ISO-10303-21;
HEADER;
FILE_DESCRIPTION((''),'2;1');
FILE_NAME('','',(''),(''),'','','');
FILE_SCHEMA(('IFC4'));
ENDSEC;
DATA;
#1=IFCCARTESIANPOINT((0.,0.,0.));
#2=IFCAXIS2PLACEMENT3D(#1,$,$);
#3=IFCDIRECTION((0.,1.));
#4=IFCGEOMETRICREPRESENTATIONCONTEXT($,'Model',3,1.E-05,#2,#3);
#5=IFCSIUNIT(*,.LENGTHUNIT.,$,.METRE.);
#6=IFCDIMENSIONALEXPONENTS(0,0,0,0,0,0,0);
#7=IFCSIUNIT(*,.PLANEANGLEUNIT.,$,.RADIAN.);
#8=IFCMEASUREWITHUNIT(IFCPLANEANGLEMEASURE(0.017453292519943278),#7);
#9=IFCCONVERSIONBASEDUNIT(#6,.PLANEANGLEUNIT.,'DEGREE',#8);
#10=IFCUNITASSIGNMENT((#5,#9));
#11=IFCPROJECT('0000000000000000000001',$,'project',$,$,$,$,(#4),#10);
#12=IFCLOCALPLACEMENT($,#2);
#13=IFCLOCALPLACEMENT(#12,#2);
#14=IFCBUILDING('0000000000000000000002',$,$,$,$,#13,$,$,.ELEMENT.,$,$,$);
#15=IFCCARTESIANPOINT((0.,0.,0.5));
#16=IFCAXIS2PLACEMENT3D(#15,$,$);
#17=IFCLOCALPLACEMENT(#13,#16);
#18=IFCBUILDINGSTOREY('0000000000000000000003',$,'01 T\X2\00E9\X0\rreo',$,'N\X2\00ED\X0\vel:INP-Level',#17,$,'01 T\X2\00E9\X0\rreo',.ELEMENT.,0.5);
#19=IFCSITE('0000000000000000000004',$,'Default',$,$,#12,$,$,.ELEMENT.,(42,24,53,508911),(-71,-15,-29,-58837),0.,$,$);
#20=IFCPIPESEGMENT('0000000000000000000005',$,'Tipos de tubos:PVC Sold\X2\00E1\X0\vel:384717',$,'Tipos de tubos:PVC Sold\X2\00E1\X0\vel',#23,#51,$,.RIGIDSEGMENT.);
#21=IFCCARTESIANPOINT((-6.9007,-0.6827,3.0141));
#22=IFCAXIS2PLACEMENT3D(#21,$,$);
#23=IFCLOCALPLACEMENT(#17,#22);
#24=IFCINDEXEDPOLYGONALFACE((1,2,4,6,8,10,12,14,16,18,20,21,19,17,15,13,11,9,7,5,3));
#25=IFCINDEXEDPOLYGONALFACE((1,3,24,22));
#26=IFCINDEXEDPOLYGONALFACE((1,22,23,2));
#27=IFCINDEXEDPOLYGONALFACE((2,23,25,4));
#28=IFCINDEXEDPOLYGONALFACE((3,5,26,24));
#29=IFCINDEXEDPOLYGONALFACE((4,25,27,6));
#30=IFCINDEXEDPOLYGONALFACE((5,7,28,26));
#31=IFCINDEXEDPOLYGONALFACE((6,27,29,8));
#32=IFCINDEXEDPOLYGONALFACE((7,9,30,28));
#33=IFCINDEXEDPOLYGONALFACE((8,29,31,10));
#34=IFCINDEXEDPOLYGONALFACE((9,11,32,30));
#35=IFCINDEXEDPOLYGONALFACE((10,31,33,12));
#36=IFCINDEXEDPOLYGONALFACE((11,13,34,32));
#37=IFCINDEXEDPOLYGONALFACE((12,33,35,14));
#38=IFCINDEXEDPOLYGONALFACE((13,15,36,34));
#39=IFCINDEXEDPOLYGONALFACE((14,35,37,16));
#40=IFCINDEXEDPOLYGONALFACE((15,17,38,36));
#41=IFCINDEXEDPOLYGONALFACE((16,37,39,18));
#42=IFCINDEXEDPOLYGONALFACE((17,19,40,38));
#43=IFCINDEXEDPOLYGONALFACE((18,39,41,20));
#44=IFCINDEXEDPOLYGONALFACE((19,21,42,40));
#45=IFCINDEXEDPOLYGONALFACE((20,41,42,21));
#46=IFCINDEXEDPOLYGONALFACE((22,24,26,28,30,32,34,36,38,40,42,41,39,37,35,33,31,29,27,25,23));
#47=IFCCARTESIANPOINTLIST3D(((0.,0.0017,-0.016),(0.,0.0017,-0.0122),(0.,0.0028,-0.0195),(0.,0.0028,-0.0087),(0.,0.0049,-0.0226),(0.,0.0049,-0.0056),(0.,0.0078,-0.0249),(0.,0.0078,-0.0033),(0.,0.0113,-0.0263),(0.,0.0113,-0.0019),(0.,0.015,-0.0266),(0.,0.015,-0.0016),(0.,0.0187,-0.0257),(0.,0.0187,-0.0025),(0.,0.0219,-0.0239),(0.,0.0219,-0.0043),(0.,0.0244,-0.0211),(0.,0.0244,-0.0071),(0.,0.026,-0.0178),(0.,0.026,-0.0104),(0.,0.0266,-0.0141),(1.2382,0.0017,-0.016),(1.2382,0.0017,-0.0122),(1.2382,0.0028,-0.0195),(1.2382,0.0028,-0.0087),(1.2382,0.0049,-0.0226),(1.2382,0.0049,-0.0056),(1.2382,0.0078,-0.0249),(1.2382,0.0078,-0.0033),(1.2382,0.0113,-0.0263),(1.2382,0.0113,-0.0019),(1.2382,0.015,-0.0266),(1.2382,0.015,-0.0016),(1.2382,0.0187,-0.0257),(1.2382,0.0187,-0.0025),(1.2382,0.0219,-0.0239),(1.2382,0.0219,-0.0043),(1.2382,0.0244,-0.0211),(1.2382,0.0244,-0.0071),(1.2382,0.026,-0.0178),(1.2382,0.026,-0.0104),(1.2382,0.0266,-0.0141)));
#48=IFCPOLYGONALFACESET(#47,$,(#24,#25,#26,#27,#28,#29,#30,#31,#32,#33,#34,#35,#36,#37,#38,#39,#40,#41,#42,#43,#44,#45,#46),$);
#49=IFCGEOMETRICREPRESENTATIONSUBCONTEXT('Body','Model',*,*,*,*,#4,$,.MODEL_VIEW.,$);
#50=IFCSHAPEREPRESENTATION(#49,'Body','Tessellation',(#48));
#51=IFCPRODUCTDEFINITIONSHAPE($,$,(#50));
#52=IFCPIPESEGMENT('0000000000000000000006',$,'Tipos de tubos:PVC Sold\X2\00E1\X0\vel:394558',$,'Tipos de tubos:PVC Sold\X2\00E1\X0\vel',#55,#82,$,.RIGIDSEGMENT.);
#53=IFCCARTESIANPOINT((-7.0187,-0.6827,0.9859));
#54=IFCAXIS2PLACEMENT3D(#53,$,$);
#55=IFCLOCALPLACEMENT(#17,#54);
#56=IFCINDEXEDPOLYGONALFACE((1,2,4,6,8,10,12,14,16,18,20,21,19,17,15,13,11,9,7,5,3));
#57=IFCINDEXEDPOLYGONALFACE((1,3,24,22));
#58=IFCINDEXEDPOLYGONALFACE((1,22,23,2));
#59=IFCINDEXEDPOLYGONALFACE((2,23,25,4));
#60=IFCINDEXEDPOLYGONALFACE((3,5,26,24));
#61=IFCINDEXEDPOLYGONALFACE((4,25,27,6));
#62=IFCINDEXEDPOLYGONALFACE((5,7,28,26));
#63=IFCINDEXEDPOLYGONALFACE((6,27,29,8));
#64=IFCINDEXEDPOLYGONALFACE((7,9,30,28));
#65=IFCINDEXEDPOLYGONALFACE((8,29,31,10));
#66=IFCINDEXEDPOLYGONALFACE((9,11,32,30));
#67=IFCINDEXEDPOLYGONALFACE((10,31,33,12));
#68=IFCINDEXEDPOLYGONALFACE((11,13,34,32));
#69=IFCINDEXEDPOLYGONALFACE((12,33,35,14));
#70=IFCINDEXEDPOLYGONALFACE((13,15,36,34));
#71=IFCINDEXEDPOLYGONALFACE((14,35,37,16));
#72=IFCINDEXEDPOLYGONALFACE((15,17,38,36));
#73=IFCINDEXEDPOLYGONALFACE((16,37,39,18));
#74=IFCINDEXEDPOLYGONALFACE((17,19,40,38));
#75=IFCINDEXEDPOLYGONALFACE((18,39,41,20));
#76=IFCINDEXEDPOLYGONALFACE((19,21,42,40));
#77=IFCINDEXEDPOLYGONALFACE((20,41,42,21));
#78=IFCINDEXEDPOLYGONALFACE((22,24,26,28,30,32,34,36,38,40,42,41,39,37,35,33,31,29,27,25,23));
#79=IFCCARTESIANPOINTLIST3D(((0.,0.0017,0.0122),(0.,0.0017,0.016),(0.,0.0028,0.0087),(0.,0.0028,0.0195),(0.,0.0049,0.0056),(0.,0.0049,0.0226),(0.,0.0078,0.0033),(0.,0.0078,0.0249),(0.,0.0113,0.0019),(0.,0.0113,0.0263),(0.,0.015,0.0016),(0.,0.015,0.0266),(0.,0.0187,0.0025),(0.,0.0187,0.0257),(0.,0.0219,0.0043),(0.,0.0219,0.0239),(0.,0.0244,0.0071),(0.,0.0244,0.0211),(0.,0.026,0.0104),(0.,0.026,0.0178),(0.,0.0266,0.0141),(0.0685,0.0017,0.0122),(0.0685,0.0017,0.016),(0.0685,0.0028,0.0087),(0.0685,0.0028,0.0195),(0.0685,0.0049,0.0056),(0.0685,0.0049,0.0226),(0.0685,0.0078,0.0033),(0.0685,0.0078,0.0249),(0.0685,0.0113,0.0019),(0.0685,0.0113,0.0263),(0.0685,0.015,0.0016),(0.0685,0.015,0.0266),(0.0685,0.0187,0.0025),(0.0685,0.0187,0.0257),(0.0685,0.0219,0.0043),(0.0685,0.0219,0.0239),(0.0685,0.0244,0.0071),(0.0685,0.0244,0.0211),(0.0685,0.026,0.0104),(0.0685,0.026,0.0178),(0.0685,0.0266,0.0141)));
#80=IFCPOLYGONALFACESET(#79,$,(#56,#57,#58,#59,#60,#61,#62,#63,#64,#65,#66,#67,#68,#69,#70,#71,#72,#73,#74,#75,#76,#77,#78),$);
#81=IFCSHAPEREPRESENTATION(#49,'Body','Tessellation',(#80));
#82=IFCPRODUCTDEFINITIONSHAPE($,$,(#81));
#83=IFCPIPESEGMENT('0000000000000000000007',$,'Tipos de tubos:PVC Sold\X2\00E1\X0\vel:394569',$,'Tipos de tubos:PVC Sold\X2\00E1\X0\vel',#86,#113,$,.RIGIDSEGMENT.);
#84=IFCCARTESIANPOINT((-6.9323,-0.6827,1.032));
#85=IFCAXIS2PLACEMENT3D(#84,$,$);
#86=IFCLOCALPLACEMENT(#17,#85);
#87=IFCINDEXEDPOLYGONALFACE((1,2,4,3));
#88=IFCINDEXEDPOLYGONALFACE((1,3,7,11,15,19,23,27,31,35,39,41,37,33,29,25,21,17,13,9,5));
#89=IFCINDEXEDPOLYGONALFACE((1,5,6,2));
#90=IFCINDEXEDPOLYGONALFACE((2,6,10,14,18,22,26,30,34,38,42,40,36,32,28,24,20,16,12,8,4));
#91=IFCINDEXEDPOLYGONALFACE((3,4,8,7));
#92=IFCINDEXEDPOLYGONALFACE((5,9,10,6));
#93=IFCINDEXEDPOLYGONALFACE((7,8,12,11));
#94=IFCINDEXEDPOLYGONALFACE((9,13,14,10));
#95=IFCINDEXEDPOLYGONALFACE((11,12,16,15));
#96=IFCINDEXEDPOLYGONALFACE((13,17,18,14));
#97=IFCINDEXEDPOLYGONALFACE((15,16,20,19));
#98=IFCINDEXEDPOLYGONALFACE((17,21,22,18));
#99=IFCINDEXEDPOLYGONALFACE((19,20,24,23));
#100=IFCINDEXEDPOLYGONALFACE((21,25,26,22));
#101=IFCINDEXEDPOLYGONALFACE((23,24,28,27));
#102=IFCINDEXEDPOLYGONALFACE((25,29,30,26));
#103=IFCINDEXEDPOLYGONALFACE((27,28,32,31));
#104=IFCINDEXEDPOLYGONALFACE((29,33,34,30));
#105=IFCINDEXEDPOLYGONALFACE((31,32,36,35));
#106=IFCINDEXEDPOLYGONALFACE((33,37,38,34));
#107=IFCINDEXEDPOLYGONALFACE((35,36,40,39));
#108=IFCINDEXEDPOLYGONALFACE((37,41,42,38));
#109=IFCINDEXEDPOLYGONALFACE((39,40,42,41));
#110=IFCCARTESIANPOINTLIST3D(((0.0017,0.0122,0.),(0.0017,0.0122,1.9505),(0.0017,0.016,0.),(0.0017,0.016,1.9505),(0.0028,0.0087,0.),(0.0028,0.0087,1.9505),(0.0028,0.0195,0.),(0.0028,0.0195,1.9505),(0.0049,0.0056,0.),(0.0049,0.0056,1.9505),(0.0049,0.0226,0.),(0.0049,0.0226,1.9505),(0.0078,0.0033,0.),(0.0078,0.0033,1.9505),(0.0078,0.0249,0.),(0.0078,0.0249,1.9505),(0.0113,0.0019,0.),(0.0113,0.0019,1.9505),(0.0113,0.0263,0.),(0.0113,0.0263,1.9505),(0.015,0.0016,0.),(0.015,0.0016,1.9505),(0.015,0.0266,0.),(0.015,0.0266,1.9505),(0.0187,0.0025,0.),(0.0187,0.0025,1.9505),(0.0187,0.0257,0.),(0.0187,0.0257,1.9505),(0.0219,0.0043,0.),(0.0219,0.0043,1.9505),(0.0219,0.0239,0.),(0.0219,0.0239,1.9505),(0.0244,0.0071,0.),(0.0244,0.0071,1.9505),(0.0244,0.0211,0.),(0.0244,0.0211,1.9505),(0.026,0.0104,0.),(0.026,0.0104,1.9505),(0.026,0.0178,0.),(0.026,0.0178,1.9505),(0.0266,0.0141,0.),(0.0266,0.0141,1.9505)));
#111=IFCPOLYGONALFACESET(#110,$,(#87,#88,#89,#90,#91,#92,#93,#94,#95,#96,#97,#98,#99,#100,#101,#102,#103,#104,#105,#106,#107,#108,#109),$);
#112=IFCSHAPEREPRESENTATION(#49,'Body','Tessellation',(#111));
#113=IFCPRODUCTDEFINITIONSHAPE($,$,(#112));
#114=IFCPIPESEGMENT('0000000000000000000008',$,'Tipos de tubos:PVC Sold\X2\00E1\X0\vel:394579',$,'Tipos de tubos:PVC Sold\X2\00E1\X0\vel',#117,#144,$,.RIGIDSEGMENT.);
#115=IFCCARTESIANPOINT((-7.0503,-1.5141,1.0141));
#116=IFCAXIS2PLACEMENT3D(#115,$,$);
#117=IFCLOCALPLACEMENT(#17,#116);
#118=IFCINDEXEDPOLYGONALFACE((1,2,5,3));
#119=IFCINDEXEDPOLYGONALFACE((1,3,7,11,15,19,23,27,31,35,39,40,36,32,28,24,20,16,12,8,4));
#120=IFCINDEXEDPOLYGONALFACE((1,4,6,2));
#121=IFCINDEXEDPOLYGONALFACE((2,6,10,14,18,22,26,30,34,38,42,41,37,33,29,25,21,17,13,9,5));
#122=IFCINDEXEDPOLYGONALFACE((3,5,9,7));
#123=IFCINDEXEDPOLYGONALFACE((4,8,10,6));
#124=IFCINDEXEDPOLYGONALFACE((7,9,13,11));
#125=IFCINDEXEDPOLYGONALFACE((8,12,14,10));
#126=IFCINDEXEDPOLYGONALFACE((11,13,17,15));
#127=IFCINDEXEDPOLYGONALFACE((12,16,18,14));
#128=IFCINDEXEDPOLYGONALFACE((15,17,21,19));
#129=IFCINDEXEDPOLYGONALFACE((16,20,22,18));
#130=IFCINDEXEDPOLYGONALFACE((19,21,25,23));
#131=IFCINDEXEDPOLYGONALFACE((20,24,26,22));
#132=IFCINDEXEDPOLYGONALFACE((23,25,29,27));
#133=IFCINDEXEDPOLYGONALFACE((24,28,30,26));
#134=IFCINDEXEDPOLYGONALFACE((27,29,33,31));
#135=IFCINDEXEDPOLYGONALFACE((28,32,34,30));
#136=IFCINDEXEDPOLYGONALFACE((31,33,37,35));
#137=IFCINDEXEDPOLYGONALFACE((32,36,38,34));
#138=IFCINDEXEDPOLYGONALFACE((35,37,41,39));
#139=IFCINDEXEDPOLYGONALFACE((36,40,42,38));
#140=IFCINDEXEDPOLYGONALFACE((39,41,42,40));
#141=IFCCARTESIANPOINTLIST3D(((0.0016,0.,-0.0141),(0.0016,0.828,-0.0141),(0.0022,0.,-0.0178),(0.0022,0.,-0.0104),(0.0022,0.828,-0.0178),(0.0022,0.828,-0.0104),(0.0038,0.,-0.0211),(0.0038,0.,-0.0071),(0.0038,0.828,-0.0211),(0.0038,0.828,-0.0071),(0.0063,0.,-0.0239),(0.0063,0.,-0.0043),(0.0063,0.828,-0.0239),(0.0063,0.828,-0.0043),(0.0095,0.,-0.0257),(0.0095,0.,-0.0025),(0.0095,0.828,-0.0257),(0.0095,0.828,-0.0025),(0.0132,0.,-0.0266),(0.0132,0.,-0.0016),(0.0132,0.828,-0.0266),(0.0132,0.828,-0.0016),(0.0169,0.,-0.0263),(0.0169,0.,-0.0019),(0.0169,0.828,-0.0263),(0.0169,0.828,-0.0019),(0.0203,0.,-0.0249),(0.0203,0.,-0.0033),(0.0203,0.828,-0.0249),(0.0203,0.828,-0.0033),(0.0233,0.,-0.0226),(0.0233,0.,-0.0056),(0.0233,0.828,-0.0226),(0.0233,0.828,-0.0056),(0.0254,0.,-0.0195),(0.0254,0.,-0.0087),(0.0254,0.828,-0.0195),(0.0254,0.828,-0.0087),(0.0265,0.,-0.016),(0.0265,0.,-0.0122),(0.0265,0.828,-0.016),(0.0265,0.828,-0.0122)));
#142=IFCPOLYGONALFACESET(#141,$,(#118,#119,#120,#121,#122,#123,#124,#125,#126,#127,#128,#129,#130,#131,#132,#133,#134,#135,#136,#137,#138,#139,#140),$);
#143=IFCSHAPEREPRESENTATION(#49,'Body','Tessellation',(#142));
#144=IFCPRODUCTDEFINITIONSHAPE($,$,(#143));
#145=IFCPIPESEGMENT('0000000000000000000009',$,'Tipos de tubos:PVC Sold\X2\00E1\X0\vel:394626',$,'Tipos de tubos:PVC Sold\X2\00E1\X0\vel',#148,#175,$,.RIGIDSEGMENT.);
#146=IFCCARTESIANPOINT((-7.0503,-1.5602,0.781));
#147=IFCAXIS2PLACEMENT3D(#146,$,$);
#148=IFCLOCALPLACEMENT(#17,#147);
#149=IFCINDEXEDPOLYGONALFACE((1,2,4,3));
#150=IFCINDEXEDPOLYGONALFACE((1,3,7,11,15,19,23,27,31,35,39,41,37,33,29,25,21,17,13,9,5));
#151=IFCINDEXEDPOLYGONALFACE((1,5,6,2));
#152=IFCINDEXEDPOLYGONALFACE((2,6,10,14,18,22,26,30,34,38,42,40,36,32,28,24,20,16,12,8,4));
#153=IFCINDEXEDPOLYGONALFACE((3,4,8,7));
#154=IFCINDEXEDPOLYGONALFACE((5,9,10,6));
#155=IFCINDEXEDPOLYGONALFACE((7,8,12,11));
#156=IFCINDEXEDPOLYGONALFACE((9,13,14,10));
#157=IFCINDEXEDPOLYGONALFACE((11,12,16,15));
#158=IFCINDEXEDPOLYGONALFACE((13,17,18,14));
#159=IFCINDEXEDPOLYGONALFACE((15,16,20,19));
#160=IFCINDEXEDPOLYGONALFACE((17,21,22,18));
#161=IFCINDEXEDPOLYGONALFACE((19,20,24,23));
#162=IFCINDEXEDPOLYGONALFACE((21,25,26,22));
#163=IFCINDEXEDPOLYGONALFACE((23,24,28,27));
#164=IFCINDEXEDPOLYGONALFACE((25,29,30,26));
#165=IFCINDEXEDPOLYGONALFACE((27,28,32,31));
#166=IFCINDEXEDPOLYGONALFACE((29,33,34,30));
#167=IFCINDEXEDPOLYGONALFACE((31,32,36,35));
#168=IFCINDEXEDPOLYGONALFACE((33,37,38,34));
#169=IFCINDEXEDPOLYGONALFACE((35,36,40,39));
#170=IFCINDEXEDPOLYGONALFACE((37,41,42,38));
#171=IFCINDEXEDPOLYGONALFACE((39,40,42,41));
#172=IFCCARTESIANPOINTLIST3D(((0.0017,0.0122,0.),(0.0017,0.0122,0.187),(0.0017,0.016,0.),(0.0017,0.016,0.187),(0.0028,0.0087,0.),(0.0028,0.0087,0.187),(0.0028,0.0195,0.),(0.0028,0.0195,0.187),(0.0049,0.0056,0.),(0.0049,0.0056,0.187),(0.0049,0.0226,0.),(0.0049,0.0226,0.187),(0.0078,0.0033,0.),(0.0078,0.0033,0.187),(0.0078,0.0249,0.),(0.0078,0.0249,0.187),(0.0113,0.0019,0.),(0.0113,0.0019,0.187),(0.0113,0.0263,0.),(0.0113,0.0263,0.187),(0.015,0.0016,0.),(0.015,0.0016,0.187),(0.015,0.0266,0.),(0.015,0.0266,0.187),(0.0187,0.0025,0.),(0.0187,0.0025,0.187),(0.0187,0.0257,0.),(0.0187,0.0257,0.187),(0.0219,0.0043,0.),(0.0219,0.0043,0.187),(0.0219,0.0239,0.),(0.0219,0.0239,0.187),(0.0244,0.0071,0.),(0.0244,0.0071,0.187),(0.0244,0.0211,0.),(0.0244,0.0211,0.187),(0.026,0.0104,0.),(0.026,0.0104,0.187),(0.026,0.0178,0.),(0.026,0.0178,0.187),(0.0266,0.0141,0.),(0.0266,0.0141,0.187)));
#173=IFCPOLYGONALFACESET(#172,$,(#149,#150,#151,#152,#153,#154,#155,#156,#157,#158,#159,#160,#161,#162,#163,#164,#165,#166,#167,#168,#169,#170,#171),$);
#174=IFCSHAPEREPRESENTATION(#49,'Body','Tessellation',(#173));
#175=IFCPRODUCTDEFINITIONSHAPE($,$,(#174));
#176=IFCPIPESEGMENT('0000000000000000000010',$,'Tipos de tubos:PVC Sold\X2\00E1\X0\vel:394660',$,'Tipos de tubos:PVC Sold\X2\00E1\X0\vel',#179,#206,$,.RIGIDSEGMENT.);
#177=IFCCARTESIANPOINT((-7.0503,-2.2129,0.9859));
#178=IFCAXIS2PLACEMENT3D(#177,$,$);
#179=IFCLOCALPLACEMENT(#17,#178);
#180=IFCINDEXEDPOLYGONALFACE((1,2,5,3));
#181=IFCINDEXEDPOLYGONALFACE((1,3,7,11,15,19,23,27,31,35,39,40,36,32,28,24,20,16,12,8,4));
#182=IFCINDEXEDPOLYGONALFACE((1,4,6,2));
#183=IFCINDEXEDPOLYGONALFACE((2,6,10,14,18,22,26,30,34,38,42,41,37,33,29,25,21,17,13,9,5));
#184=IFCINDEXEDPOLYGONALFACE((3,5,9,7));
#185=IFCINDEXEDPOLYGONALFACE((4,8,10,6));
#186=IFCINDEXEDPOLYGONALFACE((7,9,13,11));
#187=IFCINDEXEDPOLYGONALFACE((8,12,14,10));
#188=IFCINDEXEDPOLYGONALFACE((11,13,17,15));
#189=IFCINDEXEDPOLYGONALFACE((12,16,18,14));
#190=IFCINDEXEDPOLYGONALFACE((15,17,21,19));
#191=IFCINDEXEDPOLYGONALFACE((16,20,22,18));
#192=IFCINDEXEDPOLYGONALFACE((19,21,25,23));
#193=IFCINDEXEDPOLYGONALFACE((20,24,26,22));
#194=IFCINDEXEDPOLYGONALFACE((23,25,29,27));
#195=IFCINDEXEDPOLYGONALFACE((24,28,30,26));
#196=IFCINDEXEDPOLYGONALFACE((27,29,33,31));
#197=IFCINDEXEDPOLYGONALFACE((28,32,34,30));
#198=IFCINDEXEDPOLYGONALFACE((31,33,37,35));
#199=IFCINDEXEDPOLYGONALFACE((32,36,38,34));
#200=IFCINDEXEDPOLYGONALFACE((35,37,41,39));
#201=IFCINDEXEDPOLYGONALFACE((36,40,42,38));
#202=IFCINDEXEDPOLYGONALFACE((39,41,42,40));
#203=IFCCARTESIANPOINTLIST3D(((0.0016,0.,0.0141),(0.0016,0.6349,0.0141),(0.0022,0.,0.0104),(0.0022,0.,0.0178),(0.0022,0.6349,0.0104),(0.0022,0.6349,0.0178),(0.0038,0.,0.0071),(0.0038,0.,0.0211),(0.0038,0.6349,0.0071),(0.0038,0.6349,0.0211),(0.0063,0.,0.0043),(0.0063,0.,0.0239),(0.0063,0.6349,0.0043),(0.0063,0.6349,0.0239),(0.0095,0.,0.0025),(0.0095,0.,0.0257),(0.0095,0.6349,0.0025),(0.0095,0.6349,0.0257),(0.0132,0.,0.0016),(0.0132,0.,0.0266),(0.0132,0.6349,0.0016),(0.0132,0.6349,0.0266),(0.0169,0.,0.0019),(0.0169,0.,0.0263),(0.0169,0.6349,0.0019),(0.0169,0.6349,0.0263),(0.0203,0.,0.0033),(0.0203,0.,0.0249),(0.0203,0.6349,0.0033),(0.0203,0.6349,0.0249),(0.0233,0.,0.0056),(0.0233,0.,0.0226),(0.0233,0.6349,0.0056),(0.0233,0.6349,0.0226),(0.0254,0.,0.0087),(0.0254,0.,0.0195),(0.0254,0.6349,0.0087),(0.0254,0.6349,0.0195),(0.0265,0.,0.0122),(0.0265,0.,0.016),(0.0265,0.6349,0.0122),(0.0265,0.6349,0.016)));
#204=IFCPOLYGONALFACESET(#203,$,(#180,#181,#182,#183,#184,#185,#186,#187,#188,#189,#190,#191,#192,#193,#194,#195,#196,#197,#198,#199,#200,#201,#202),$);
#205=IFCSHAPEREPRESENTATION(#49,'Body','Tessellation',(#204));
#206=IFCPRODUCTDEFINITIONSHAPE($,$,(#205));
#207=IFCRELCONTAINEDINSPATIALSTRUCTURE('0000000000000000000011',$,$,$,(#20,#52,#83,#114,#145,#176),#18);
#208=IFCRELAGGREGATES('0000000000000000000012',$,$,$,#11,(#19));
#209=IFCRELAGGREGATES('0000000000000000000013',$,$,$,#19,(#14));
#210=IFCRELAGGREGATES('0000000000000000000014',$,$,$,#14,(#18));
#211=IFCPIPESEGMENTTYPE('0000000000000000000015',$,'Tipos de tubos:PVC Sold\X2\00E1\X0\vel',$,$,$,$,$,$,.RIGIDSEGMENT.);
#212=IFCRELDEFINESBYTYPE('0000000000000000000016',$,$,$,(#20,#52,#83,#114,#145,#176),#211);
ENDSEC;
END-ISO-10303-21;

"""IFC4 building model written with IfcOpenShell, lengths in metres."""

from ifc_helpers import new_model, entity, si_unit, converted_unit, direction, frame, frame_2d, origin, origin_2d_with_axis, place, context, subcontext, project, spatial, circle, extrude, type_object, element, save


model = new_model("IFC4")

# Units and contexts
model_context = context("Model", 3, precision=1e-05, world=origin(), true_north=direction((0.0, 1.0)))
body_context = subcontext(model_context, "Body", "Model", "MODEL_VIEW")
ifc_project = project(units=[si_unit("LENGTHUNIT", "METRE"), converted_unit("PLANEANGLEUNIT", "DEGREE", entity("IfcPlaneAngleMeasure", 0.017453292519943278), si_unit("PLANEANGLEUNIT", "RADIAN"), dimensions=[0, 0, 0, 0, 0, 0, 0])], contexts=[model_context])

# Site, building, storey
site_placement = place(None, origin())
site = spatial("IfcSite", under=ifc_project, at=site_placement, Name="Default", CompositionType="ELEMENT", RefLatitude=(42, 24, 53, 508911), RefLongitude=(-71, -15, -29, -58837), RefElevation=0.0)
building_placement = place(site_placement, origin())
building = spatial("IfcBuilding", under=site, at=building_placement, CompositionType="ELEMENT")
storey_placement = place(building_placement, frame((0.0, 0.0, 0.5)))
storey = spatial("IfcBuildingStorey", under=building, at=storey_placement, Name="01 Térreo", ObjectType="Nível:INP-Level", LongName="01 Térreo", CompositionType="ELEMENT", Elevation=0.5)

# Pipe segments
pipe_segment_type = type_object("IfcPipeSegmentType", Name="Tipos de tubos:PVC Soldável", PredefinedType="RIGIDSEGMENT")
pipe_segment_1_placement = place(storey_placement, frame((-6.9007, -0.6827, 3.0141)))
element("IfcPipeSegment", 1, at=pipe_segment_1_placement, inside=storey, type_object=pipe_segment_type, Name="Tipos de tubos:PVC Soldável:384717", ObjectType="Tipos de tubos:PVC Soldável", PredefinedType="RIGIDSEGMENT", context=body_context, shape_type="SweptSolid", body=[
    extrude(circle(Radius=0.0125, at=frame_2d((0.0, 0.0), x_axis=(1.0, 0.0))), frame((0.0, 0.0141, -0.0141), z_axis=(1.0, 0.0, 0.0), x_axis=(0.0, 1.0, 0.0)), (0.0, 0.0, 1.0), 1.2382),
])
pipe_segment_2_placement = place(storey_placement, frame((-7.0187, -0.6827, 0.9859)))
element("IfcPipeSegment", 2, at=pipe_segment_2_placement, inside=storey, type_object=pipe_segment_type, Name="Tipos de tubos:PVC Soldável:394558", ObjectType="Tipos de tubos:PVC Soldável", PredefinedType="RIGIDSEGMENT", context=body_context, shape_type="SweptSolid", body=[
    extrude(circle(Radius=0.0125, at=frame_2d((0.0, 0.0), x_axis=(1.0, 0.0))), frame((0.0, 0.0141, 0.0141), z_axis=(1.0, 0.0, 0.0), x_axis=(0.0, 1.0, 0.0)), (0.0, 0.0, 1.0), 0.0685),
])
pipe_segment_3_placement = place(storey_placement, frame((-6.9323, -0.6827, 1.032)))
element("IfcPipeSegment", 3, at=pipe_segment_3_placement, inside=storey, type_object=pipe_segment_type, Name="Tipos de tubos:PVC Soldável:394569", ObjectType="Tipos de tubos:PVC Soldável", PredefinedType="RIGIDSEGMENT", context=body_context, shape_type="SweptSolid", body=[
    extrude(circle(Radius=0.0125, at=origin_2d_with_axis()), frame((0.0141, 0.0141, 0.0)), (0.0, 0.0, 1.0), 1.9505),
])
pipe_segment_4_placement = place(storey_placement, frame((-7.0503, -1.5141, 1.0141)))
element("IfcPipeSegment", 4, at=pipe_segment_4_placement, inside=storey, type_object=pipe_segment_type, Name="Tipos de tubos:PVC Soldável:394579", ObjectType="Tipos de tubos:PVC Soldável", PredefinedType="RIGIDSEGMENT", context=body_context, shape_type="SweptSolid", body=[
    extrude(circle(Radius=0.0125, at=frame_2d((0.0, 0.0), x_axis=(1.0, 0.0))), frame((0.0141, 0.0, -0.0141), z_axis=(0.0, 1.0, 0.0), x_axis=(-1.0, 0.0, 0.0)), (0.0, 0.0, 1.0), 0.828),
])
pipe_segment_5_placement = place(storey_placement, frame((-7.0503, -1.5602, 0.781)))
element("IfcPipeSegment", 5, at=pipe_segment_5_placement, inside=storey, type_object=pipe_segment_type, Name="Tipos de tubos:PVC Soldável:394626", ObjectType="Tipos de tubos:PVC Soldável", PredefinedType="RIGIDSEGMENT", context=body_context, shape_type="SweptSolid", body=[
    extrude(circle(Radius=0.0125, at=origin_2d_with_axis()), frame((0.0141, 0.0141, 0.0)), (0.0, 0.0, 1.0), 0.187),
])
pipe_segment_6_placement = place(storey_placement, frame((-7.0503, -2.2129, 0.9859)))
element("IfcPipeSegment", 6, at=pipe_segment_6_placement, inside=storey, type_object=pipe_segment_type, Name="Tipos de tubos:PVC Soldável:394660", ObjectType="Tipos de tubos:PVC Soldável", PredefinedType="RIGIDSEGMENT", context=body_context, shape_type="SweptSolid", body=[
    extrude(circle(Radius=0.0125, at=origin_2d_with_axis()), frame((0.0141, 0.0, 0.0141), z_axis=(0.0, 1.0, 0.0), x_axis=(-1.0, 0.0, 0.0)), (0.0, 0.0, 1.0), 0.6349),
])

save(model, "model.ifc")
